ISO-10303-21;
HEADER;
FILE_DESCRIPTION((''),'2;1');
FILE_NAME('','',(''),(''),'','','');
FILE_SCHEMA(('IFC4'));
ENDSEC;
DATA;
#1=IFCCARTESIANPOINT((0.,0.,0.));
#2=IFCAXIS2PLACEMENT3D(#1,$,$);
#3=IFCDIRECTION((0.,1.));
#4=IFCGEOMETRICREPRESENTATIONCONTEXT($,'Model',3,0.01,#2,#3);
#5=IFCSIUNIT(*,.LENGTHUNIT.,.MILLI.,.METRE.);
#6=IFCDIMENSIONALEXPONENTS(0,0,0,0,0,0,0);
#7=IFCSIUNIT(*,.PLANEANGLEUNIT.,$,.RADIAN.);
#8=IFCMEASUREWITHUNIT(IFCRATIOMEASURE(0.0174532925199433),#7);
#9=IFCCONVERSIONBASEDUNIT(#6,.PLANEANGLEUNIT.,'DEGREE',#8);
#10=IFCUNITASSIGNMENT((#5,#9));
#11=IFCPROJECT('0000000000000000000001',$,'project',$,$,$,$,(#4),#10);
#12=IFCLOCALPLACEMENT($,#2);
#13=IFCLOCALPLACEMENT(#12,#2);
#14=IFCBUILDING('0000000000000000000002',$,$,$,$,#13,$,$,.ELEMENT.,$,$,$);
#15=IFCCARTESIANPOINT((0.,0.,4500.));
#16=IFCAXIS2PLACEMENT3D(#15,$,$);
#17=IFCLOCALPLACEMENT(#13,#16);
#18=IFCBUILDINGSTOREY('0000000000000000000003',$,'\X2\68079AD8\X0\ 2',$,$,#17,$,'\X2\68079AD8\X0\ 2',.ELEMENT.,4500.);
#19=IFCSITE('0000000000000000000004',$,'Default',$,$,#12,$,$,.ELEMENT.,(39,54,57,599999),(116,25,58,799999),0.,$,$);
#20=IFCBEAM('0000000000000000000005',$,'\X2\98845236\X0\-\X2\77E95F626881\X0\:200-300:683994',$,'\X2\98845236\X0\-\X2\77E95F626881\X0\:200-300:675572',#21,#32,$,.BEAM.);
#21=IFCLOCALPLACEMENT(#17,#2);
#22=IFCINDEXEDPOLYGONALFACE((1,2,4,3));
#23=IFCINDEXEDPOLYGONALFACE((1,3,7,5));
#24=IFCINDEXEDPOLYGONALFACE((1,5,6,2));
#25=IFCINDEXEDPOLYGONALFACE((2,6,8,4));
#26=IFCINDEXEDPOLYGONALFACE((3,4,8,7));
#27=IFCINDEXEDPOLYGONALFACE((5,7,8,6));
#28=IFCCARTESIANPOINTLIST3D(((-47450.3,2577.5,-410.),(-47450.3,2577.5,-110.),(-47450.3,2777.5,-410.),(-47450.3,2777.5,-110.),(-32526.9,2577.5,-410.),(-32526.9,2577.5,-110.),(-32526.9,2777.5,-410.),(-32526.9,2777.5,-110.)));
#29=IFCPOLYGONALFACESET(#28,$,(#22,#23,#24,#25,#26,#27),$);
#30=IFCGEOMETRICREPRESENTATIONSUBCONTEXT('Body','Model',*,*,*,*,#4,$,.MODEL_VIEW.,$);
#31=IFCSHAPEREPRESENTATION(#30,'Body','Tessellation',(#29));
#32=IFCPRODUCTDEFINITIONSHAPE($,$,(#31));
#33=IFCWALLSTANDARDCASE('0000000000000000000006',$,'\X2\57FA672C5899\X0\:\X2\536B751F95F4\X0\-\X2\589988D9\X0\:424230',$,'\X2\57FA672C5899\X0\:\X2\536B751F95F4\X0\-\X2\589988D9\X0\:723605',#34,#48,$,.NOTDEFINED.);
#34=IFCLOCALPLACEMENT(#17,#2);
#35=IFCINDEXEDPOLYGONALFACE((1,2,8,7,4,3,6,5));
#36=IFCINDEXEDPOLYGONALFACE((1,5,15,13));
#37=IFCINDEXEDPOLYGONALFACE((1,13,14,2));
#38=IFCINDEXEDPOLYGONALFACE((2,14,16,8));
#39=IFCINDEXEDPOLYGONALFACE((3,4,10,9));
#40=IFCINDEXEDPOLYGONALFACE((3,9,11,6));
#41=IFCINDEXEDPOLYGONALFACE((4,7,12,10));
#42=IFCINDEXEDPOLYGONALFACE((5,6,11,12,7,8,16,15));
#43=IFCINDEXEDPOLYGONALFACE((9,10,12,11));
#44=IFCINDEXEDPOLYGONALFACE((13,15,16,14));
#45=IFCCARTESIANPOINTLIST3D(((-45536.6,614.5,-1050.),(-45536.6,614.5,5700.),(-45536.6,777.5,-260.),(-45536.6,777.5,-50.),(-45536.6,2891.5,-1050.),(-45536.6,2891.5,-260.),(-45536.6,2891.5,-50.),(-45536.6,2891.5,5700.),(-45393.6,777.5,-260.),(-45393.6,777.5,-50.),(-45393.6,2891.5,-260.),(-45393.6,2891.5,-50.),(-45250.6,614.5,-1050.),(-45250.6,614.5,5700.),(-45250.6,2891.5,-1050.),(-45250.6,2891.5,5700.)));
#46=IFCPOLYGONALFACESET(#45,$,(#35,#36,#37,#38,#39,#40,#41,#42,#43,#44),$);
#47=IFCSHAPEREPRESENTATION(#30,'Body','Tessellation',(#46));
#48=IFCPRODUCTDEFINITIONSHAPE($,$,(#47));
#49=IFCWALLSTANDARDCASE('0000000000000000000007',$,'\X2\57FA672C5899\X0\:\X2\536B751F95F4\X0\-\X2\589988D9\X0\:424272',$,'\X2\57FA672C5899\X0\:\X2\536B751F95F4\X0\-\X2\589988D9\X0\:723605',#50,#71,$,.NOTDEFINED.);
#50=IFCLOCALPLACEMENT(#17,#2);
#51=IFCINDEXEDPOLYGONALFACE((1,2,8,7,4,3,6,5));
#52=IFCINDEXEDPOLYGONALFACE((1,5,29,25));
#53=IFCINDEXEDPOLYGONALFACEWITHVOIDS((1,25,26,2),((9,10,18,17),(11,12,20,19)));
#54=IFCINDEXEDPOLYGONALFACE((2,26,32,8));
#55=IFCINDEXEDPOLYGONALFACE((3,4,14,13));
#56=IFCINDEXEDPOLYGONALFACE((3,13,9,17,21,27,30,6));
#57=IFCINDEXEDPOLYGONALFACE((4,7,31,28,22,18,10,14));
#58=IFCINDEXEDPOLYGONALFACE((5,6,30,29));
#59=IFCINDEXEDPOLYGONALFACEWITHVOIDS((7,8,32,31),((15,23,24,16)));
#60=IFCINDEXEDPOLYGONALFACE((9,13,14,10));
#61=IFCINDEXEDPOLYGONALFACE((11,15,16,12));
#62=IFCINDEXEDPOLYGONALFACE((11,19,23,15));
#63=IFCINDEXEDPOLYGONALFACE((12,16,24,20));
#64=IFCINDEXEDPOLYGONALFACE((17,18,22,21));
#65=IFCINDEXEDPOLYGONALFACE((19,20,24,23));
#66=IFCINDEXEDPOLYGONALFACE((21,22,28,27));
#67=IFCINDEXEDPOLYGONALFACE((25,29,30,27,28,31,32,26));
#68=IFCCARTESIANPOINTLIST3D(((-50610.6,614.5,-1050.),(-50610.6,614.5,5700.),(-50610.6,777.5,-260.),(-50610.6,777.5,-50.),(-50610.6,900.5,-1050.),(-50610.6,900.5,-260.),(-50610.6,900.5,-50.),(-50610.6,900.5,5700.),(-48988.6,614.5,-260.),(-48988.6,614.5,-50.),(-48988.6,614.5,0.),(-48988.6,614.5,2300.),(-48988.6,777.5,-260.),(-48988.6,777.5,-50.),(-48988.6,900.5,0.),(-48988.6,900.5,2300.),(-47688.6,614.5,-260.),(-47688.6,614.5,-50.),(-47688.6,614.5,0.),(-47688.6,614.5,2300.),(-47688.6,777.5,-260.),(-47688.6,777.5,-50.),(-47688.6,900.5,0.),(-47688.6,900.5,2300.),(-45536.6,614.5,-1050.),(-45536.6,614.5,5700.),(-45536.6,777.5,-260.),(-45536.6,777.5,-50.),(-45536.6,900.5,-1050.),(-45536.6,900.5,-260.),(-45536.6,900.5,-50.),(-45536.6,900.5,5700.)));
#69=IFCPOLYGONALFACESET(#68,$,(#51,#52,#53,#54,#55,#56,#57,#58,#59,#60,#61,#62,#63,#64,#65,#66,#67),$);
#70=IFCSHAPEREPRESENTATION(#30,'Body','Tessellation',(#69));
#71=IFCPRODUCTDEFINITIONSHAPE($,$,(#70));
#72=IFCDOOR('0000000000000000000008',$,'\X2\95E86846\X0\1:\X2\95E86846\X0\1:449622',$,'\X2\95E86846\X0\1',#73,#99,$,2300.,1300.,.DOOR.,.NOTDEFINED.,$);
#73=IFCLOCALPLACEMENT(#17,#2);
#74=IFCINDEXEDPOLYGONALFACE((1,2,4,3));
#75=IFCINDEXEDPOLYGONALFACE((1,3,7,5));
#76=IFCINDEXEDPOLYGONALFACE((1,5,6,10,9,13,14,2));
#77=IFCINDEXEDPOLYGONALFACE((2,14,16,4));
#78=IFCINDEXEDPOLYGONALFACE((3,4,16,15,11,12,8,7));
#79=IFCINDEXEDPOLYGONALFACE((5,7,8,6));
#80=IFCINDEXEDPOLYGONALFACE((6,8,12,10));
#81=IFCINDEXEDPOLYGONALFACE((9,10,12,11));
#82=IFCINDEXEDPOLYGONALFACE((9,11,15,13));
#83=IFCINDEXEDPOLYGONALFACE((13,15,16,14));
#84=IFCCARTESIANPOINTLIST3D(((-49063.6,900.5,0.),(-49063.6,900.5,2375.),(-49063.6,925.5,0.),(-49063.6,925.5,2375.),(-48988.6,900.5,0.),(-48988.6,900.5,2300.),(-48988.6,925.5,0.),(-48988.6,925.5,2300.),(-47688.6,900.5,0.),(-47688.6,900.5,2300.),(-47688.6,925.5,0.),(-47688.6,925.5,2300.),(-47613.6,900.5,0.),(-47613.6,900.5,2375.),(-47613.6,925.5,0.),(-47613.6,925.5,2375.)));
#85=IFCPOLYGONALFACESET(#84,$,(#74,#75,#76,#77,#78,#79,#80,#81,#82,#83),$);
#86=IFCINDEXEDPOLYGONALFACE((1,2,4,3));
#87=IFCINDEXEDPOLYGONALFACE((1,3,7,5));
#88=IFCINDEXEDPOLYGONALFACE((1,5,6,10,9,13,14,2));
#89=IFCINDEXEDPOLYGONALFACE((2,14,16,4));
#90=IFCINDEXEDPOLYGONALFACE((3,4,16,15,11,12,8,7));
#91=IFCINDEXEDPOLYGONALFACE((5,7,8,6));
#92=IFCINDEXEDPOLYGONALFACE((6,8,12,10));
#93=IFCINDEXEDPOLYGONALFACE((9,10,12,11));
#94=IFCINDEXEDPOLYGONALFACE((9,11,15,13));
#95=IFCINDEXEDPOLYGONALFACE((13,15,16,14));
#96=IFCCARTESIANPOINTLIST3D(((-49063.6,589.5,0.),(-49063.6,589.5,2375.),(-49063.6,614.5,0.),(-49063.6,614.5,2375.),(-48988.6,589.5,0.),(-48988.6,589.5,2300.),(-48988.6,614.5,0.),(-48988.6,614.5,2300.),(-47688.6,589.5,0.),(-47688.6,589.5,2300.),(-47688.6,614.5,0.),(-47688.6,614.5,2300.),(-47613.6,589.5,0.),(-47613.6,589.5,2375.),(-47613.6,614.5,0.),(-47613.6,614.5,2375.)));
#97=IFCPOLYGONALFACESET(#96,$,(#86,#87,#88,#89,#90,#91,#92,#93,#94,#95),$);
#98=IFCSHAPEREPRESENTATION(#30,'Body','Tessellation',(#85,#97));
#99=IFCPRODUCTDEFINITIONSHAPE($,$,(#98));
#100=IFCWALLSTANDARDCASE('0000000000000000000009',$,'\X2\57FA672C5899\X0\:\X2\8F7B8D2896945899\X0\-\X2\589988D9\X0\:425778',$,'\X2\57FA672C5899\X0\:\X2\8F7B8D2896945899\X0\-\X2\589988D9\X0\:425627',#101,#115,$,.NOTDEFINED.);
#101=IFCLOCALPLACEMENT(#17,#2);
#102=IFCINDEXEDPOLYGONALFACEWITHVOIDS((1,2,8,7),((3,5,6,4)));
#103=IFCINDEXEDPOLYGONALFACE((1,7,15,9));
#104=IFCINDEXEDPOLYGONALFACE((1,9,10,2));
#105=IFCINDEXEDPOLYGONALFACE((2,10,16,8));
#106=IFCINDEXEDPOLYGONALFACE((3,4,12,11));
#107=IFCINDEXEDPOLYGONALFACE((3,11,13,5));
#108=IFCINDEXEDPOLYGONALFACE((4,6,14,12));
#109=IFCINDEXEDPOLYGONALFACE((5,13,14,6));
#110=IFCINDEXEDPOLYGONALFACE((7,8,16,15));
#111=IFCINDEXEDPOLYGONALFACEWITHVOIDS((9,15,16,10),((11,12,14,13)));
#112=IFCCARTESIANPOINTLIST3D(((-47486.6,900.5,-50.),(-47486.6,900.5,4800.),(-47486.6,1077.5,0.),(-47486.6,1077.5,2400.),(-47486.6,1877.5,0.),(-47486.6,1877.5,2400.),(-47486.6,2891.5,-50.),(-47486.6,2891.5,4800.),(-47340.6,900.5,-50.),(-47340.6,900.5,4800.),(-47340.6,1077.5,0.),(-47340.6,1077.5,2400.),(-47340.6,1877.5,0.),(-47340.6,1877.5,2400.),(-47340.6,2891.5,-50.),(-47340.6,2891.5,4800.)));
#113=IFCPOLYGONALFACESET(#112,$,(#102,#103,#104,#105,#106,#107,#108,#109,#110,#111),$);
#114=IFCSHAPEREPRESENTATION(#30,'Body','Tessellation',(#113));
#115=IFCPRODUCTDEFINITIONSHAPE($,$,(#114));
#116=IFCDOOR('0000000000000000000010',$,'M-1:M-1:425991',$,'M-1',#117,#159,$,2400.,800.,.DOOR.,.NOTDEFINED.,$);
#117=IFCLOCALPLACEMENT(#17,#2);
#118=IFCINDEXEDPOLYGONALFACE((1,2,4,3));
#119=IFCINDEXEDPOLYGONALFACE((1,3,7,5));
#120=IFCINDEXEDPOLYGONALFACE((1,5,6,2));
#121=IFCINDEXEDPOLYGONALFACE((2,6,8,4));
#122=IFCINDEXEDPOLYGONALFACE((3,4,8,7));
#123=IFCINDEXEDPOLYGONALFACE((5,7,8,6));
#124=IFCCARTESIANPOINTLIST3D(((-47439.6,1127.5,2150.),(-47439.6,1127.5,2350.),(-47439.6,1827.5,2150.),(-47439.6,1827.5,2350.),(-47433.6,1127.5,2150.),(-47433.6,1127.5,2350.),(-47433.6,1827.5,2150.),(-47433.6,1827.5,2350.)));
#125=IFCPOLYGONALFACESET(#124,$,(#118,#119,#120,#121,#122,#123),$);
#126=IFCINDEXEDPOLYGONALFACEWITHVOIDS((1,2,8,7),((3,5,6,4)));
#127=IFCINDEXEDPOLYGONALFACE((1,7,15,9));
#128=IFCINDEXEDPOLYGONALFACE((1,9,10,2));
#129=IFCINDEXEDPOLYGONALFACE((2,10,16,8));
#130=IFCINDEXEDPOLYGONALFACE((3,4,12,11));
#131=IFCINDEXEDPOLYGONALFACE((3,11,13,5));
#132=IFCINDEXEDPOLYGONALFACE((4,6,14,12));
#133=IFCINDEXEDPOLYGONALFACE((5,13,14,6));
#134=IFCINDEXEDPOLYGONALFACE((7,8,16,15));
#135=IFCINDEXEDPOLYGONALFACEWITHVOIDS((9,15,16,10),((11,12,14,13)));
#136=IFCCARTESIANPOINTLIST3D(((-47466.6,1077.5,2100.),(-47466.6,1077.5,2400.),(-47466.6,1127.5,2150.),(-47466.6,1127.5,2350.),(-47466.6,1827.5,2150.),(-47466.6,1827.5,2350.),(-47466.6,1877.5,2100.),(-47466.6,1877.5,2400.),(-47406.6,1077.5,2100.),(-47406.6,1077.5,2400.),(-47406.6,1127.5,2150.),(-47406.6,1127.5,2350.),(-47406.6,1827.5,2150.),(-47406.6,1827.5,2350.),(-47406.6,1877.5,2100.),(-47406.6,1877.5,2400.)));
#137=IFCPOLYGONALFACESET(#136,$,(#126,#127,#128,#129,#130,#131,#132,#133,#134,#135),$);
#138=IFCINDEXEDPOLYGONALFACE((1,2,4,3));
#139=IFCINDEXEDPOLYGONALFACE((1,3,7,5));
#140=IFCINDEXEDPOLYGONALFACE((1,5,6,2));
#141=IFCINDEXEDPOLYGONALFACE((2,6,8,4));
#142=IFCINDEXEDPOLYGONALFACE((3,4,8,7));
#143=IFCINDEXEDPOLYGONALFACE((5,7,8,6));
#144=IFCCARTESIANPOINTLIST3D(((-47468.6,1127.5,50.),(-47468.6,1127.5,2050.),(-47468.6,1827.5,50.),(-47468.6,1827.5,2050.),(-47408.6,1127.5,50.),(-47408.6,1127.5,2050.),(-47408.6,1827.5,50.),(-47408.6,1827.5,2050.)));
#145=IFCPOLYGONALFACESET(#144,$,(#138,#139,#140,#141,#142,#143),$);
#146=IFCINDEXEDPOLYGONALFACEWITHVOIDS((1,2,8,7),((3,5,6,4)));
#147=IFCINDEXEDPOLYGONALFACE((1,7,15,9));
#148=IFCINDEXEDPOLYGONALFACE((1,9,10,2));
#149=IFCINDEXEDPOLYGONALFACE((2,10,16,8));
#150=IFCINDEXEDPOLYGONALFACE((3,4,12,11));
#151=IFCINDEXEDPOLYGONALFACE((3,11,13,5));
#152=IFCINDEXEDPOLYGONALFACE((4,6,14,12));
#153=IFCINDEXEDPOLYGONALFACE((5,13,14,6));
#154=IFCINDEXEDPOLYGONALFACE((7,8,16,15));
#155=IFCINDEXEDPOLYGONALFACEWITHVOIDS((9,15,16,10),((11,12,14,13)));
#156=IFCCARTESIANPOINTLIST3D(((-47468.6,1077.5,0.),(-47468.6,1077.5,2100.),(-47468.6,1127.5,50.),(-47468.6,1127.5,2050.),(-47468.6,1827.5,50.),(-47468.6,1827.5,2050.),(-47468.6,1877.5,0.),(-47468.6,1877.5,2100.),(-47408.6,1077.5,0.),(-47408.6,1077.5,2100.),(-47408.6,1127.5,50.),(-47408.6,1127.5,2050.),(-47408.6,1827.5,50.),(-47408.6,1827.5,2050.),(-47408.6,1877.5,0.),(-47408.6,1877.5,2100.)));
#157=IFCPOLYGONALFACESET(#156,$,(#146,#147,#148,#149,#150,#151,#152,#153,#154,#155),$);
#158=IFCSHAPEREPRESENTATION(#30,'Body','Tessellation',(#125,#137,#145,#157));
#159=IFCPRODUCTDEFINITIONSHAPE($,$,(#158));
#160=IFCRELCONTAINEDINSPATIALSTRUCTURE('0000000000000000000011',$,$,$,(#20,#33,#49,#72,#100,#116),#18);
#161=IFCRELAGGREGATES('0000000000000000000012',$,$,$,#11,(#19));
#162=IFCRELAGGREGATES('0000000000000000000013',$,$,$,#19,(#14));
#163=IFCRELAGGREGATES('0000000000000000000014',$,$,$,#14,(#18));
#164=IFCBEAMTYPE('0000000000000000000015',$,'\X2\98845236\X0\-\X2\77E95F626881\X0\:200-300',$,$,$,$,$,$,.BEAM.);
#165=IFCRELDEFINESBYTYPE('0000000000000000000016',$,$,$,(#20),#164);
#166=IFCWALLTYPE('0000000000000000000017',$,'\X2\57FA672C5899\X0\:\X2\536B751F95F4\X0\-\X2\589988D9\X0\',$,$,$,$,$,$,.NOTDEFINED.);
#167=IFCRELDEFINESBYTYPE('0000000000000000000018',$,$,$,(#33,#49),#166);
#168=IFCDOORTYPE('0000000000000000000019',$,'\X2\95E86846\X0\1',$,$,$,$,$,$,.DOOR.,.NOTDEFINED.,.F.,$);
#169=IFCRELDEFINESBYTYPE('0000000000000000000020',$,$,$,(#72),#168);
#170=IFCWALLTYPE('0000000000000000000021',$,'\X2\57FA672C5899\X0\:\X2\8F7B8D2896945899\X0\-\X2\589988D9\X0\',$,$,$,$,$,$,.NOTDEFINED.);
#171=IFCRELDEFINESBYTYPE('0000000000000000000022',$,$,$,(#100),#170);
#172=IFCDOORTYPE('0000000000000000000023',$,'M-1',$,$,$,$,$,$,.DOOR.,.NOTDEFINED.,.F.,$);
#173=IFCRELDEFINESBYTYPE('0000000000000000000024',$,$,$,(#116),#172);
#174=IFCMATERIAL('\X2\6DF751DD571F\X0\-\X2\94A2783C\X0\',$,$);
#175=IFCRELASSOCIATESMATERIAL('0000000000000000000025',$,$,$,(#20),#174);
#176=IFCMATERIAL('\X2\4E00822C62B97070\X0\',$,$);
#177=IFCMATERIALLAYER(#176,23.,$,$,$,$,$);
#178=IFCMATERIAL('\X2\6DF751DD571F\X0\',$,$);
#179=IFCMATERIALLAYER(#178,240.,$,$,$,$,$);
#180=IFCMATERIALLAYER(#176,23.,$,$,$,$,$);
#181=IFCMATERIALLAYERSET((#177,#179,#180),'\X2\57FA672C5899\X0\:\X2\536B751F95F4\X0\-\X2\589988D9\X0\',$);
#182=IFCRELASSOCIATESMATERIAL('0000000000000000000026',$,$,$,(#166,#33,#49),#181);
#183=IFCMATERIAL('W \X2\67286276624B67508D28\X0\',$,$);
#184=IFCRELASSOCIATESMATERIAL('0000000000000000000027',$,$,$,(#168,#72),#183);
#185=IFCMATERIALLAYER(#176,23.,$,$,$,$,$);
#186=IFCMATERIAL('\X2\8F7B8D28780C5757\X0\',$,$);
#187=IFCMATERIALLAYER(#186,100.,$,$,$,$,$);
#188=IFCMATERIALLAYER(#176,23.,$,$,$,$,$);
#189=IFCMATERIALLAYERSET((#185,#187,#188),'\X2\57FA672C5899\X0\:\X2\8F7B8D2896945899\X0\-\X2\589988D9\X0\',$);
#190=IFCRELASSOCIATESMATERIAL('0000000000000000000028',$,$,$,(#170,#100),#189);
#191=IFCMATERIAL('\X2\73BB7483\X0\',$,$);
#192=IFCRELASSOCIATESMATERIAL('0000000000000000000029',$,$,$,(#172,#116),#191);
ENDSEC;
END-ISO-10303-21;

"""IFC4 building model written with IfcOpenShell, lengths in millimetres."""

from ifc_helpers import new_model, entity, si_unit, converted_unit, direction, frame, frame_2d, origin, place, context, subcontext, project, spatial, polyline, rectangle, outline, extrude, source, transform, mapped, material, layer, layer_set, layer_usage, type_object, type_shapes, element, fill, save


model = new_model("IFC4")

# Units and contexts
model_context = context("Model", 3, precision=0.01, world=origin(), true_north=direction((0.0, 1.0)))
body_context = subcontext(model_context, "Body", "Model", "MODEL_VIEW")
ifc_project = project(units=[si_unit("LENGTHUNIT", "METRE", prefix="MILLI"), converted_unit("PLANEANGLEUNIT", "DEGREE", entity("IfcRatioMeasure", 0.0174532925199433), si_unit("PLANEANGLEUNIT", "RADIAN"), dimensions=[0, 0, 0, 0, 0, 0, 0])], contexts=[model_context])

# Site, building, storey
site_placement = place(None, origin())
site = spatial("IfcSite", under=ifc_project, at=site_placement, Name="Default", CompositionType="ELEMENT", RefLatitude=(39, 54, 57, 599999), RefLongitude=(116, 25, 58, 799999), RefElevation=0.0)
building_placement = place(site_placement, origin())
building = spatial("IfcBuilding", under=site, at=building_placement, CompositionType="ELEMENT")
storey_placement = place(building_placement, frame((0.0, 0.0, 4500.0)))
storey = spatial("IfcBuildingStorey", under=building, at=storey_placement, Name="标高 2", LongName="标高 2", CompositionType="ELEMENT", Elevation=4500.0)

# Beam
ifc_material_1 = material(Name="混凝土-钢砼")
beam_type = type_object("IfcBeamType", Name="预制-矩形梁:200-300", PredefinedType="BEAM")
beam_placement = place(storey_placement, frame((-47413.6, 2677.5, -110.0)))
element("IfcBeam", 1, at=beam_placement, inside=storey, type_object=beam_type, material=ifc_material_1, Name="预制-矩形梁:200-300:683994", ObjectType="预制-矩形梁:200-300:675572", PredefinedType="BEAM", context=body_context, shape_type="SweptSolid", body=[
    extrude(rectangle(XDim=300.0, YDim=200.0, at=frame_2d((0.0, 0.0), x_axis=(1.0, 0.0))), frame((-36.7, 0.0, -150.0), z_axis=(1.0, 0.0, 0.0), x_axis=(0.0, 0.0, -1.0)), (0.0, 0.0, 1.0), 14923.4),
])

# Wall, opening
ifc_material_2 = material(Name="一般抹灰")
ifc_layer_1 = layer(ifc_material_2, 23.0)
ifc_material_3 = material(Name="混凝土")
ifc_layer_2 = layer(ifc_material_3, 240.0)
ifc_layer_3 = layer(ifc_material_2, 23.0)
ifc_layer_set_1 = layer_set([ifc_layer_1, ifc_layer_2, ifc_layer_3], Name="基本墙:卫生间-墙裙")
ifc_layer_usage_1 = layer_usage(ifc_layer_set_1, "AXIS2", "NEGATIVE", 143.0)
wall_type_1 = type_object("IfcWallType", Name="基本墙:卫生间-墙裙", PredefinedType="NOTDEFINED", material=ifc_layer_set_1)
wall_1_placement = place(storey_placement, frame((-45393.6, 2891.5, -1050.0), z_axis=(0.0, 0.0, 1.0), x_axis=(0.0, -1.0, 0.0)))
wall_1 = element("IfcWallStandardCase", 2, at=wall_1_placement, inside=storey, type_object=wall_type_1, material=ifc_layer_usage_1, Name="基本墙:卫生间-墙裙:424230", ObjectType="基本墙:卫生间-墙裙:723605", PredefinedType="NOTDEFINED", context=body_context, shape_type="SweptSolid", body=[
    extrude(rectangle(XDim=2277.0, YDim=286.0, at=frame_2d((1138.5, 0.0), x_axis=(-1.0, 0.0))), origin(), (0.0, 0.0, 1.0), 6750.0),
])
opening_1_placement = place(storey_placement, frame((-45393.6, 2891.5, -1050.0), z_axis=(0.0, 0.0, 1.0), x_axis=(0.0, -1.0, 0.0)))
element("IfcOpeningElement", 3, at=opening_1_placement, cuts=wall_1, ObjectType="Opening", PredefinedType="OPENING", context=body_context, shape_type="SweptSolid", body=[
    extrude(rectangle(XDim=143.0, YDim=2114.0, at=frame_2d((14.3, 186.8), x_axis=(1.0, 0.0))), frame((1243.8, -85.8, 790.0), z_axis=(0.0, 0.0, 1.0), x_axis=(0.0, 1.0, 0.0)), (0.0, 0.0, 1.0), 210.0),
])

# Wall, openings, door
ifc_layer_usage_2 = layer_usage(ifc_layer_set_1, "AXIS2", "NEGATIVE", 143.0)
wall_2_placement = place(storey_placement, frame((-45536.6, 757.5, -1050.0), z_axis=(0.0, 0.0, 1.0), x_axis=(-1.0, 0.0, 0.0)))
wall_2 = element("IfcWallStandardCase", 4, at=wall_2_placement, inside=storey, type_object=wall_type_1, material=ifc_layer_usage_2, Name="基本墙:卫生间-墙裙:424272", ObjectType="基本墙:卫生间-墙裙:723605", PredefinedType="NOTDEFINED", context=body_context, shape_type="SweptSolid", body=[
    extrude(rectangle(XDim=5074.0, YDim=286.0, at=frame_2d((2537.0, 0.0), x_axis=(-1.0, 0.0))), origin(), (0.0, 0.0, 1.0), 6750.0),
])
opening_2_placement = place(storey_placement, frame((-45536.6, 757.5, -1050.0), z_axis=(0.0, 0.0, 1.0), x_axis=(-1.0, 0.0, 0.0)))
element("IfcOpeningElement", 5, at=opening_2_placement, cuts=wall_2, ObjectType="Opening", PredefinedType="OPENING", context=body_context, shape_type="SweptSolid", body=[
    extrude(outline(polyline([(517.5, 10.0), (2669.5, 10.0), (2669.5, 133.0), (-2404.5, 133.0), (-2404.5, 10.0), (-782.5, 10.0), (-782.5, -153.0), (517.5, -153.0), (517.5, 10.0)])), frame((2669.5, -10.0, 790.0), z_axis=(0.0, 0.0, 1.0), x_axis=(-1.0, 0.0, 0.0)), (0.0, 0.0, 1.0), 210.0),
])
opening_3_placement = place(wall_2_placement, frame((3452.0, 143.0, 1050.0)))
opening_3 = element("IfcOpeningElement", 6, at=opening_3_placement, cuts=wall_2, ObjectType="Opening", PredefinedType="OPENING", context=body_context, shape_type="SweptSolid", body=[
    extrude(rectangle(XDim=2300.0, YDim=1300.0, at=frame_2d((1150.0, 650.0), x_axis=(1.0, 0.0))), frame((0.0, 0.0, 0.0), z_axis=(0.0, -1.0, 0.0), x_axis=(0.0, 0.0, 1.0)), (0.0, 0.0, 1.0), 286.0),
])
ifc_material_4 = material(Name="W 木扶手材质")
door_type_1 = type_object("IfcDoorType", Name="门框1", OperationType="NOTDEFINED", ParameterTakesPrecedence=False, PredefinedType="DOOR", material=ifc_material_4)
shared_shape_1 = source(origin(), body_context, "Body", "SweptSolid", [
    extrude(outline(polyline([(-1131.2, 650.0), (1168.7, 650.0), (1168.7, 725.0), (-1206.2, 725.0), (-1206.2, -725.0), (1168.7, -725.0), (1168.7, -650.0), (-1131.2, -650.0), (-1131.2, 650.0)])), frame((650.0, 286.0, 1168.7), z_axis=(0.0, 1.0, 0.0), x_axis=(0.0, 0.0, -1.0)), (0.0, 0.0, 1.0), 25.0),
    extrude(outline(polyline([(-725.0, -1206.2), (725.0, -1206.2), (725.0, 1168.7), (650.0, 1168.7), (650.0, -1131.2), (-650.0, -1131.2), (-650.0, 1168.7), (-725.0, 1168.7), (-725.0, -1206.2)])), frame((650.0, -25.0, 1168.7), z_axis=(0.0, 1.0, 0.0), x_axis=(1.0, 0.0, 0.0)), (0.0, 0.0, 1.0), 25.0),
])
type_shapes(door_type_1, [shared_shape_1])
door_1_placement = place(opening_3_placement, frame((0.0, 0.0, 0.0), z_axis=(0.0, 0.0, 1.0), x_axis=(-1.0, 0.0, 0.0)))
door_1 = element("IfcDoor", 7, at=door_1_placement, inside=storey, type_object=door_type_1, material=ifc_material_4, Name="门框1:门框1:449622", ObjectType="门框1", OperationType="NOTDEFINED", OverallHeight=2300.0, OverallWidth=1300.0, PredefinedType="DOOR", context=body_context, shape_type="MappedRepresentation", body=[
    mapped(shared_shape_1, transform((0.0, 0.0, 0.0), scale=1.0)),
])
fill(opening_3, door_1)

# Wall, opening, door
ifc_layer_4 = layer(ifc_material_2, 23.0)
ifc_material_5 = material(Name="轻质砌块")
ifc_layer_5 = layer(ifc_material_5, 100.0)
ifc_layer_6 = layer(ifc_material_2, 23.0)
ifc_layer_set_2 = layer_set([ifc_layer_4, ifc_layer_5, ifc_layer_6], Name="基本墙:轻质隔墙-墙裙")
ifc_layer_usage_3 = layer_usage(ifc_layer_set_2, "AXIS2", "NEGATIVE", 73.0)
wall_type_2 = type_object("IfcWallType", Name="基本墙:轻质隔墙-墙裙", PredefinedType="NOTDEFINED", material=ifc_layer_set_2)
wall_3_placement = place(storey_placement, frame((-47413.6, 900.5, -50.0), z_axis=(0.0, 0.0, 1.0), x_axis=(0.0, 1.0, 0.0)))
wall_3 = element("IfcWallStandardCase", 8, at=wall_3_placement, inside=storey, type_object=wall_type_2, material=ifc_layer_usage_3, Name="基本墙:轻质隔墙-墙裙:425778", ObjectType="基本墙:轻质隔墙-墙裙:425627", PredefinedType="NOTDEFINED", context=body_context, shape_type="SweptSolid", body=[
    extrude(rectangle(XDim=1991.0, YDim=146.0, at=frame_2d((995.5, 0.0), x_axis=(-1.0, 0.0))), origin(), (0.0, 0.0, 1.0), 4850.0),
])
opening_4_placement = place(wall_3_placement, frame((977.0, 73.0, 50.0)))
opening_4 = element("IfcOpeningElement", 9, at=opening_4_placement, cuts=wall_3, ObjectType="Opening", PredefinedType="OPENING", context=body_context, shape_type="SweptSolid", body=[
    extrude(rectangle(XDim=2400.0, YDim=800.0, at=frame_2d((1200.0, 400.0), x_axis=(1.0, 0.0))), frame((0.0, 0.0, 0.0), z_axis=(0.0, -1.0, 0.0), x_axis=(0.0, 0.0, 1.0)), (0.0, 0.0, 1.0), 146.0),
])
ifc_material_6 = material(Name="玻璃")
door_type_2 = type_object("IfcDoorType", Name="M-1", OperationType="NOTDEFINED", ParameterTakesPrecedence=False, PredefinedType="DOOR", material=ifc_material_6)
shared_shape_2 = source(origin(), body_context, "Body", "SweptSolid", [
    extrude(rectangle(XDim=700.0, YDim=6.0, at=frame_2d((0.0, 0.0), x_axis=(1.0, 0.0))), frame((400.0, 50.0, 2150.0), z_axis=(0.0, 0.0, 1.0), x_axis=(-1.0, 0.0, 0.0)), (0.0, 0.0, 1.0), 200.0),
    extrude(outline(polyline([(-400.0, -150.0), (400.0, -150.0), (400.0, 150.0), (-400.0, 150.0), (-400.0, -150.0)]), holes=[polyline([(-350.0, -100.0), (-350.0, 100.0), (350.0, 100.0), (350.0, -100.0), (-350.0, -100.0)])]), frame((400.0, 80.0, 2250.0), z_axis=(0.0, -1.0, 0.0), x_axis=(-1.0, 0.0, 0.0)), (0.0, 0.0, 1.0), 60.0),
    extrude(rectangle(XDim=60.0, YDim=700.0, at=frame_2d((0.0, 0.0), x_axis=(1.0, 0.0))), frame((400.0, 48.0, 50.0), z_axis=(0.0, 0.0, 1.0), x_axis=(0.0, -1.0, 0.0)), (0.0, 0.0, 1.0), 2000.0),
    extrude(outline(polyline([(-1050.0, -400.0), (1050.0, -400.0), (1050.0, 400.0), (-1050.0, 400.0), (-1050.0, -400.0)]), holes=[polyline([(-1000.0, 350.0), (1000.0, 350.0), (1000.0, -350.0), (-1000.0, -350.0), (-1000.0, 350.0)])]), frame((400.0, 78.0, 1050.0), z_axis=(0.0, -1.0, 0.0), x_axis=(0.0, 0.0, -1.0)), (0.0, 0.0, 1.0), 60.0),
])
type_shapes(door_type_2, [shared_shape_2])
door_2_placement = place(opening_4_placement, frame((0.0, 0.0, 0.0), z_axis=(0.0, 0.0, 1.0), x_axis=(-1.0, 0.0, 0.0)))
door_2 = element("IfcDoor", 10, at=door_2_placement, inside=storey, type_object=door_type_2, material=ifc_material_6, Name="M-1:M-1:425991", ObjectType="M-1", OperationType="NOTDEFINED", OverallHeight=2400.0, OverallWidth=800.0, PredefinedType="DOOR", context=body_context, shape_type="MappedRepresentation", body=[
    mapped(shared_shape_2, transform((0.0, 0.0, 0.0), scale=1.0)),
])
fill(opening_4, door_2)

save(model, "model.ifc")
